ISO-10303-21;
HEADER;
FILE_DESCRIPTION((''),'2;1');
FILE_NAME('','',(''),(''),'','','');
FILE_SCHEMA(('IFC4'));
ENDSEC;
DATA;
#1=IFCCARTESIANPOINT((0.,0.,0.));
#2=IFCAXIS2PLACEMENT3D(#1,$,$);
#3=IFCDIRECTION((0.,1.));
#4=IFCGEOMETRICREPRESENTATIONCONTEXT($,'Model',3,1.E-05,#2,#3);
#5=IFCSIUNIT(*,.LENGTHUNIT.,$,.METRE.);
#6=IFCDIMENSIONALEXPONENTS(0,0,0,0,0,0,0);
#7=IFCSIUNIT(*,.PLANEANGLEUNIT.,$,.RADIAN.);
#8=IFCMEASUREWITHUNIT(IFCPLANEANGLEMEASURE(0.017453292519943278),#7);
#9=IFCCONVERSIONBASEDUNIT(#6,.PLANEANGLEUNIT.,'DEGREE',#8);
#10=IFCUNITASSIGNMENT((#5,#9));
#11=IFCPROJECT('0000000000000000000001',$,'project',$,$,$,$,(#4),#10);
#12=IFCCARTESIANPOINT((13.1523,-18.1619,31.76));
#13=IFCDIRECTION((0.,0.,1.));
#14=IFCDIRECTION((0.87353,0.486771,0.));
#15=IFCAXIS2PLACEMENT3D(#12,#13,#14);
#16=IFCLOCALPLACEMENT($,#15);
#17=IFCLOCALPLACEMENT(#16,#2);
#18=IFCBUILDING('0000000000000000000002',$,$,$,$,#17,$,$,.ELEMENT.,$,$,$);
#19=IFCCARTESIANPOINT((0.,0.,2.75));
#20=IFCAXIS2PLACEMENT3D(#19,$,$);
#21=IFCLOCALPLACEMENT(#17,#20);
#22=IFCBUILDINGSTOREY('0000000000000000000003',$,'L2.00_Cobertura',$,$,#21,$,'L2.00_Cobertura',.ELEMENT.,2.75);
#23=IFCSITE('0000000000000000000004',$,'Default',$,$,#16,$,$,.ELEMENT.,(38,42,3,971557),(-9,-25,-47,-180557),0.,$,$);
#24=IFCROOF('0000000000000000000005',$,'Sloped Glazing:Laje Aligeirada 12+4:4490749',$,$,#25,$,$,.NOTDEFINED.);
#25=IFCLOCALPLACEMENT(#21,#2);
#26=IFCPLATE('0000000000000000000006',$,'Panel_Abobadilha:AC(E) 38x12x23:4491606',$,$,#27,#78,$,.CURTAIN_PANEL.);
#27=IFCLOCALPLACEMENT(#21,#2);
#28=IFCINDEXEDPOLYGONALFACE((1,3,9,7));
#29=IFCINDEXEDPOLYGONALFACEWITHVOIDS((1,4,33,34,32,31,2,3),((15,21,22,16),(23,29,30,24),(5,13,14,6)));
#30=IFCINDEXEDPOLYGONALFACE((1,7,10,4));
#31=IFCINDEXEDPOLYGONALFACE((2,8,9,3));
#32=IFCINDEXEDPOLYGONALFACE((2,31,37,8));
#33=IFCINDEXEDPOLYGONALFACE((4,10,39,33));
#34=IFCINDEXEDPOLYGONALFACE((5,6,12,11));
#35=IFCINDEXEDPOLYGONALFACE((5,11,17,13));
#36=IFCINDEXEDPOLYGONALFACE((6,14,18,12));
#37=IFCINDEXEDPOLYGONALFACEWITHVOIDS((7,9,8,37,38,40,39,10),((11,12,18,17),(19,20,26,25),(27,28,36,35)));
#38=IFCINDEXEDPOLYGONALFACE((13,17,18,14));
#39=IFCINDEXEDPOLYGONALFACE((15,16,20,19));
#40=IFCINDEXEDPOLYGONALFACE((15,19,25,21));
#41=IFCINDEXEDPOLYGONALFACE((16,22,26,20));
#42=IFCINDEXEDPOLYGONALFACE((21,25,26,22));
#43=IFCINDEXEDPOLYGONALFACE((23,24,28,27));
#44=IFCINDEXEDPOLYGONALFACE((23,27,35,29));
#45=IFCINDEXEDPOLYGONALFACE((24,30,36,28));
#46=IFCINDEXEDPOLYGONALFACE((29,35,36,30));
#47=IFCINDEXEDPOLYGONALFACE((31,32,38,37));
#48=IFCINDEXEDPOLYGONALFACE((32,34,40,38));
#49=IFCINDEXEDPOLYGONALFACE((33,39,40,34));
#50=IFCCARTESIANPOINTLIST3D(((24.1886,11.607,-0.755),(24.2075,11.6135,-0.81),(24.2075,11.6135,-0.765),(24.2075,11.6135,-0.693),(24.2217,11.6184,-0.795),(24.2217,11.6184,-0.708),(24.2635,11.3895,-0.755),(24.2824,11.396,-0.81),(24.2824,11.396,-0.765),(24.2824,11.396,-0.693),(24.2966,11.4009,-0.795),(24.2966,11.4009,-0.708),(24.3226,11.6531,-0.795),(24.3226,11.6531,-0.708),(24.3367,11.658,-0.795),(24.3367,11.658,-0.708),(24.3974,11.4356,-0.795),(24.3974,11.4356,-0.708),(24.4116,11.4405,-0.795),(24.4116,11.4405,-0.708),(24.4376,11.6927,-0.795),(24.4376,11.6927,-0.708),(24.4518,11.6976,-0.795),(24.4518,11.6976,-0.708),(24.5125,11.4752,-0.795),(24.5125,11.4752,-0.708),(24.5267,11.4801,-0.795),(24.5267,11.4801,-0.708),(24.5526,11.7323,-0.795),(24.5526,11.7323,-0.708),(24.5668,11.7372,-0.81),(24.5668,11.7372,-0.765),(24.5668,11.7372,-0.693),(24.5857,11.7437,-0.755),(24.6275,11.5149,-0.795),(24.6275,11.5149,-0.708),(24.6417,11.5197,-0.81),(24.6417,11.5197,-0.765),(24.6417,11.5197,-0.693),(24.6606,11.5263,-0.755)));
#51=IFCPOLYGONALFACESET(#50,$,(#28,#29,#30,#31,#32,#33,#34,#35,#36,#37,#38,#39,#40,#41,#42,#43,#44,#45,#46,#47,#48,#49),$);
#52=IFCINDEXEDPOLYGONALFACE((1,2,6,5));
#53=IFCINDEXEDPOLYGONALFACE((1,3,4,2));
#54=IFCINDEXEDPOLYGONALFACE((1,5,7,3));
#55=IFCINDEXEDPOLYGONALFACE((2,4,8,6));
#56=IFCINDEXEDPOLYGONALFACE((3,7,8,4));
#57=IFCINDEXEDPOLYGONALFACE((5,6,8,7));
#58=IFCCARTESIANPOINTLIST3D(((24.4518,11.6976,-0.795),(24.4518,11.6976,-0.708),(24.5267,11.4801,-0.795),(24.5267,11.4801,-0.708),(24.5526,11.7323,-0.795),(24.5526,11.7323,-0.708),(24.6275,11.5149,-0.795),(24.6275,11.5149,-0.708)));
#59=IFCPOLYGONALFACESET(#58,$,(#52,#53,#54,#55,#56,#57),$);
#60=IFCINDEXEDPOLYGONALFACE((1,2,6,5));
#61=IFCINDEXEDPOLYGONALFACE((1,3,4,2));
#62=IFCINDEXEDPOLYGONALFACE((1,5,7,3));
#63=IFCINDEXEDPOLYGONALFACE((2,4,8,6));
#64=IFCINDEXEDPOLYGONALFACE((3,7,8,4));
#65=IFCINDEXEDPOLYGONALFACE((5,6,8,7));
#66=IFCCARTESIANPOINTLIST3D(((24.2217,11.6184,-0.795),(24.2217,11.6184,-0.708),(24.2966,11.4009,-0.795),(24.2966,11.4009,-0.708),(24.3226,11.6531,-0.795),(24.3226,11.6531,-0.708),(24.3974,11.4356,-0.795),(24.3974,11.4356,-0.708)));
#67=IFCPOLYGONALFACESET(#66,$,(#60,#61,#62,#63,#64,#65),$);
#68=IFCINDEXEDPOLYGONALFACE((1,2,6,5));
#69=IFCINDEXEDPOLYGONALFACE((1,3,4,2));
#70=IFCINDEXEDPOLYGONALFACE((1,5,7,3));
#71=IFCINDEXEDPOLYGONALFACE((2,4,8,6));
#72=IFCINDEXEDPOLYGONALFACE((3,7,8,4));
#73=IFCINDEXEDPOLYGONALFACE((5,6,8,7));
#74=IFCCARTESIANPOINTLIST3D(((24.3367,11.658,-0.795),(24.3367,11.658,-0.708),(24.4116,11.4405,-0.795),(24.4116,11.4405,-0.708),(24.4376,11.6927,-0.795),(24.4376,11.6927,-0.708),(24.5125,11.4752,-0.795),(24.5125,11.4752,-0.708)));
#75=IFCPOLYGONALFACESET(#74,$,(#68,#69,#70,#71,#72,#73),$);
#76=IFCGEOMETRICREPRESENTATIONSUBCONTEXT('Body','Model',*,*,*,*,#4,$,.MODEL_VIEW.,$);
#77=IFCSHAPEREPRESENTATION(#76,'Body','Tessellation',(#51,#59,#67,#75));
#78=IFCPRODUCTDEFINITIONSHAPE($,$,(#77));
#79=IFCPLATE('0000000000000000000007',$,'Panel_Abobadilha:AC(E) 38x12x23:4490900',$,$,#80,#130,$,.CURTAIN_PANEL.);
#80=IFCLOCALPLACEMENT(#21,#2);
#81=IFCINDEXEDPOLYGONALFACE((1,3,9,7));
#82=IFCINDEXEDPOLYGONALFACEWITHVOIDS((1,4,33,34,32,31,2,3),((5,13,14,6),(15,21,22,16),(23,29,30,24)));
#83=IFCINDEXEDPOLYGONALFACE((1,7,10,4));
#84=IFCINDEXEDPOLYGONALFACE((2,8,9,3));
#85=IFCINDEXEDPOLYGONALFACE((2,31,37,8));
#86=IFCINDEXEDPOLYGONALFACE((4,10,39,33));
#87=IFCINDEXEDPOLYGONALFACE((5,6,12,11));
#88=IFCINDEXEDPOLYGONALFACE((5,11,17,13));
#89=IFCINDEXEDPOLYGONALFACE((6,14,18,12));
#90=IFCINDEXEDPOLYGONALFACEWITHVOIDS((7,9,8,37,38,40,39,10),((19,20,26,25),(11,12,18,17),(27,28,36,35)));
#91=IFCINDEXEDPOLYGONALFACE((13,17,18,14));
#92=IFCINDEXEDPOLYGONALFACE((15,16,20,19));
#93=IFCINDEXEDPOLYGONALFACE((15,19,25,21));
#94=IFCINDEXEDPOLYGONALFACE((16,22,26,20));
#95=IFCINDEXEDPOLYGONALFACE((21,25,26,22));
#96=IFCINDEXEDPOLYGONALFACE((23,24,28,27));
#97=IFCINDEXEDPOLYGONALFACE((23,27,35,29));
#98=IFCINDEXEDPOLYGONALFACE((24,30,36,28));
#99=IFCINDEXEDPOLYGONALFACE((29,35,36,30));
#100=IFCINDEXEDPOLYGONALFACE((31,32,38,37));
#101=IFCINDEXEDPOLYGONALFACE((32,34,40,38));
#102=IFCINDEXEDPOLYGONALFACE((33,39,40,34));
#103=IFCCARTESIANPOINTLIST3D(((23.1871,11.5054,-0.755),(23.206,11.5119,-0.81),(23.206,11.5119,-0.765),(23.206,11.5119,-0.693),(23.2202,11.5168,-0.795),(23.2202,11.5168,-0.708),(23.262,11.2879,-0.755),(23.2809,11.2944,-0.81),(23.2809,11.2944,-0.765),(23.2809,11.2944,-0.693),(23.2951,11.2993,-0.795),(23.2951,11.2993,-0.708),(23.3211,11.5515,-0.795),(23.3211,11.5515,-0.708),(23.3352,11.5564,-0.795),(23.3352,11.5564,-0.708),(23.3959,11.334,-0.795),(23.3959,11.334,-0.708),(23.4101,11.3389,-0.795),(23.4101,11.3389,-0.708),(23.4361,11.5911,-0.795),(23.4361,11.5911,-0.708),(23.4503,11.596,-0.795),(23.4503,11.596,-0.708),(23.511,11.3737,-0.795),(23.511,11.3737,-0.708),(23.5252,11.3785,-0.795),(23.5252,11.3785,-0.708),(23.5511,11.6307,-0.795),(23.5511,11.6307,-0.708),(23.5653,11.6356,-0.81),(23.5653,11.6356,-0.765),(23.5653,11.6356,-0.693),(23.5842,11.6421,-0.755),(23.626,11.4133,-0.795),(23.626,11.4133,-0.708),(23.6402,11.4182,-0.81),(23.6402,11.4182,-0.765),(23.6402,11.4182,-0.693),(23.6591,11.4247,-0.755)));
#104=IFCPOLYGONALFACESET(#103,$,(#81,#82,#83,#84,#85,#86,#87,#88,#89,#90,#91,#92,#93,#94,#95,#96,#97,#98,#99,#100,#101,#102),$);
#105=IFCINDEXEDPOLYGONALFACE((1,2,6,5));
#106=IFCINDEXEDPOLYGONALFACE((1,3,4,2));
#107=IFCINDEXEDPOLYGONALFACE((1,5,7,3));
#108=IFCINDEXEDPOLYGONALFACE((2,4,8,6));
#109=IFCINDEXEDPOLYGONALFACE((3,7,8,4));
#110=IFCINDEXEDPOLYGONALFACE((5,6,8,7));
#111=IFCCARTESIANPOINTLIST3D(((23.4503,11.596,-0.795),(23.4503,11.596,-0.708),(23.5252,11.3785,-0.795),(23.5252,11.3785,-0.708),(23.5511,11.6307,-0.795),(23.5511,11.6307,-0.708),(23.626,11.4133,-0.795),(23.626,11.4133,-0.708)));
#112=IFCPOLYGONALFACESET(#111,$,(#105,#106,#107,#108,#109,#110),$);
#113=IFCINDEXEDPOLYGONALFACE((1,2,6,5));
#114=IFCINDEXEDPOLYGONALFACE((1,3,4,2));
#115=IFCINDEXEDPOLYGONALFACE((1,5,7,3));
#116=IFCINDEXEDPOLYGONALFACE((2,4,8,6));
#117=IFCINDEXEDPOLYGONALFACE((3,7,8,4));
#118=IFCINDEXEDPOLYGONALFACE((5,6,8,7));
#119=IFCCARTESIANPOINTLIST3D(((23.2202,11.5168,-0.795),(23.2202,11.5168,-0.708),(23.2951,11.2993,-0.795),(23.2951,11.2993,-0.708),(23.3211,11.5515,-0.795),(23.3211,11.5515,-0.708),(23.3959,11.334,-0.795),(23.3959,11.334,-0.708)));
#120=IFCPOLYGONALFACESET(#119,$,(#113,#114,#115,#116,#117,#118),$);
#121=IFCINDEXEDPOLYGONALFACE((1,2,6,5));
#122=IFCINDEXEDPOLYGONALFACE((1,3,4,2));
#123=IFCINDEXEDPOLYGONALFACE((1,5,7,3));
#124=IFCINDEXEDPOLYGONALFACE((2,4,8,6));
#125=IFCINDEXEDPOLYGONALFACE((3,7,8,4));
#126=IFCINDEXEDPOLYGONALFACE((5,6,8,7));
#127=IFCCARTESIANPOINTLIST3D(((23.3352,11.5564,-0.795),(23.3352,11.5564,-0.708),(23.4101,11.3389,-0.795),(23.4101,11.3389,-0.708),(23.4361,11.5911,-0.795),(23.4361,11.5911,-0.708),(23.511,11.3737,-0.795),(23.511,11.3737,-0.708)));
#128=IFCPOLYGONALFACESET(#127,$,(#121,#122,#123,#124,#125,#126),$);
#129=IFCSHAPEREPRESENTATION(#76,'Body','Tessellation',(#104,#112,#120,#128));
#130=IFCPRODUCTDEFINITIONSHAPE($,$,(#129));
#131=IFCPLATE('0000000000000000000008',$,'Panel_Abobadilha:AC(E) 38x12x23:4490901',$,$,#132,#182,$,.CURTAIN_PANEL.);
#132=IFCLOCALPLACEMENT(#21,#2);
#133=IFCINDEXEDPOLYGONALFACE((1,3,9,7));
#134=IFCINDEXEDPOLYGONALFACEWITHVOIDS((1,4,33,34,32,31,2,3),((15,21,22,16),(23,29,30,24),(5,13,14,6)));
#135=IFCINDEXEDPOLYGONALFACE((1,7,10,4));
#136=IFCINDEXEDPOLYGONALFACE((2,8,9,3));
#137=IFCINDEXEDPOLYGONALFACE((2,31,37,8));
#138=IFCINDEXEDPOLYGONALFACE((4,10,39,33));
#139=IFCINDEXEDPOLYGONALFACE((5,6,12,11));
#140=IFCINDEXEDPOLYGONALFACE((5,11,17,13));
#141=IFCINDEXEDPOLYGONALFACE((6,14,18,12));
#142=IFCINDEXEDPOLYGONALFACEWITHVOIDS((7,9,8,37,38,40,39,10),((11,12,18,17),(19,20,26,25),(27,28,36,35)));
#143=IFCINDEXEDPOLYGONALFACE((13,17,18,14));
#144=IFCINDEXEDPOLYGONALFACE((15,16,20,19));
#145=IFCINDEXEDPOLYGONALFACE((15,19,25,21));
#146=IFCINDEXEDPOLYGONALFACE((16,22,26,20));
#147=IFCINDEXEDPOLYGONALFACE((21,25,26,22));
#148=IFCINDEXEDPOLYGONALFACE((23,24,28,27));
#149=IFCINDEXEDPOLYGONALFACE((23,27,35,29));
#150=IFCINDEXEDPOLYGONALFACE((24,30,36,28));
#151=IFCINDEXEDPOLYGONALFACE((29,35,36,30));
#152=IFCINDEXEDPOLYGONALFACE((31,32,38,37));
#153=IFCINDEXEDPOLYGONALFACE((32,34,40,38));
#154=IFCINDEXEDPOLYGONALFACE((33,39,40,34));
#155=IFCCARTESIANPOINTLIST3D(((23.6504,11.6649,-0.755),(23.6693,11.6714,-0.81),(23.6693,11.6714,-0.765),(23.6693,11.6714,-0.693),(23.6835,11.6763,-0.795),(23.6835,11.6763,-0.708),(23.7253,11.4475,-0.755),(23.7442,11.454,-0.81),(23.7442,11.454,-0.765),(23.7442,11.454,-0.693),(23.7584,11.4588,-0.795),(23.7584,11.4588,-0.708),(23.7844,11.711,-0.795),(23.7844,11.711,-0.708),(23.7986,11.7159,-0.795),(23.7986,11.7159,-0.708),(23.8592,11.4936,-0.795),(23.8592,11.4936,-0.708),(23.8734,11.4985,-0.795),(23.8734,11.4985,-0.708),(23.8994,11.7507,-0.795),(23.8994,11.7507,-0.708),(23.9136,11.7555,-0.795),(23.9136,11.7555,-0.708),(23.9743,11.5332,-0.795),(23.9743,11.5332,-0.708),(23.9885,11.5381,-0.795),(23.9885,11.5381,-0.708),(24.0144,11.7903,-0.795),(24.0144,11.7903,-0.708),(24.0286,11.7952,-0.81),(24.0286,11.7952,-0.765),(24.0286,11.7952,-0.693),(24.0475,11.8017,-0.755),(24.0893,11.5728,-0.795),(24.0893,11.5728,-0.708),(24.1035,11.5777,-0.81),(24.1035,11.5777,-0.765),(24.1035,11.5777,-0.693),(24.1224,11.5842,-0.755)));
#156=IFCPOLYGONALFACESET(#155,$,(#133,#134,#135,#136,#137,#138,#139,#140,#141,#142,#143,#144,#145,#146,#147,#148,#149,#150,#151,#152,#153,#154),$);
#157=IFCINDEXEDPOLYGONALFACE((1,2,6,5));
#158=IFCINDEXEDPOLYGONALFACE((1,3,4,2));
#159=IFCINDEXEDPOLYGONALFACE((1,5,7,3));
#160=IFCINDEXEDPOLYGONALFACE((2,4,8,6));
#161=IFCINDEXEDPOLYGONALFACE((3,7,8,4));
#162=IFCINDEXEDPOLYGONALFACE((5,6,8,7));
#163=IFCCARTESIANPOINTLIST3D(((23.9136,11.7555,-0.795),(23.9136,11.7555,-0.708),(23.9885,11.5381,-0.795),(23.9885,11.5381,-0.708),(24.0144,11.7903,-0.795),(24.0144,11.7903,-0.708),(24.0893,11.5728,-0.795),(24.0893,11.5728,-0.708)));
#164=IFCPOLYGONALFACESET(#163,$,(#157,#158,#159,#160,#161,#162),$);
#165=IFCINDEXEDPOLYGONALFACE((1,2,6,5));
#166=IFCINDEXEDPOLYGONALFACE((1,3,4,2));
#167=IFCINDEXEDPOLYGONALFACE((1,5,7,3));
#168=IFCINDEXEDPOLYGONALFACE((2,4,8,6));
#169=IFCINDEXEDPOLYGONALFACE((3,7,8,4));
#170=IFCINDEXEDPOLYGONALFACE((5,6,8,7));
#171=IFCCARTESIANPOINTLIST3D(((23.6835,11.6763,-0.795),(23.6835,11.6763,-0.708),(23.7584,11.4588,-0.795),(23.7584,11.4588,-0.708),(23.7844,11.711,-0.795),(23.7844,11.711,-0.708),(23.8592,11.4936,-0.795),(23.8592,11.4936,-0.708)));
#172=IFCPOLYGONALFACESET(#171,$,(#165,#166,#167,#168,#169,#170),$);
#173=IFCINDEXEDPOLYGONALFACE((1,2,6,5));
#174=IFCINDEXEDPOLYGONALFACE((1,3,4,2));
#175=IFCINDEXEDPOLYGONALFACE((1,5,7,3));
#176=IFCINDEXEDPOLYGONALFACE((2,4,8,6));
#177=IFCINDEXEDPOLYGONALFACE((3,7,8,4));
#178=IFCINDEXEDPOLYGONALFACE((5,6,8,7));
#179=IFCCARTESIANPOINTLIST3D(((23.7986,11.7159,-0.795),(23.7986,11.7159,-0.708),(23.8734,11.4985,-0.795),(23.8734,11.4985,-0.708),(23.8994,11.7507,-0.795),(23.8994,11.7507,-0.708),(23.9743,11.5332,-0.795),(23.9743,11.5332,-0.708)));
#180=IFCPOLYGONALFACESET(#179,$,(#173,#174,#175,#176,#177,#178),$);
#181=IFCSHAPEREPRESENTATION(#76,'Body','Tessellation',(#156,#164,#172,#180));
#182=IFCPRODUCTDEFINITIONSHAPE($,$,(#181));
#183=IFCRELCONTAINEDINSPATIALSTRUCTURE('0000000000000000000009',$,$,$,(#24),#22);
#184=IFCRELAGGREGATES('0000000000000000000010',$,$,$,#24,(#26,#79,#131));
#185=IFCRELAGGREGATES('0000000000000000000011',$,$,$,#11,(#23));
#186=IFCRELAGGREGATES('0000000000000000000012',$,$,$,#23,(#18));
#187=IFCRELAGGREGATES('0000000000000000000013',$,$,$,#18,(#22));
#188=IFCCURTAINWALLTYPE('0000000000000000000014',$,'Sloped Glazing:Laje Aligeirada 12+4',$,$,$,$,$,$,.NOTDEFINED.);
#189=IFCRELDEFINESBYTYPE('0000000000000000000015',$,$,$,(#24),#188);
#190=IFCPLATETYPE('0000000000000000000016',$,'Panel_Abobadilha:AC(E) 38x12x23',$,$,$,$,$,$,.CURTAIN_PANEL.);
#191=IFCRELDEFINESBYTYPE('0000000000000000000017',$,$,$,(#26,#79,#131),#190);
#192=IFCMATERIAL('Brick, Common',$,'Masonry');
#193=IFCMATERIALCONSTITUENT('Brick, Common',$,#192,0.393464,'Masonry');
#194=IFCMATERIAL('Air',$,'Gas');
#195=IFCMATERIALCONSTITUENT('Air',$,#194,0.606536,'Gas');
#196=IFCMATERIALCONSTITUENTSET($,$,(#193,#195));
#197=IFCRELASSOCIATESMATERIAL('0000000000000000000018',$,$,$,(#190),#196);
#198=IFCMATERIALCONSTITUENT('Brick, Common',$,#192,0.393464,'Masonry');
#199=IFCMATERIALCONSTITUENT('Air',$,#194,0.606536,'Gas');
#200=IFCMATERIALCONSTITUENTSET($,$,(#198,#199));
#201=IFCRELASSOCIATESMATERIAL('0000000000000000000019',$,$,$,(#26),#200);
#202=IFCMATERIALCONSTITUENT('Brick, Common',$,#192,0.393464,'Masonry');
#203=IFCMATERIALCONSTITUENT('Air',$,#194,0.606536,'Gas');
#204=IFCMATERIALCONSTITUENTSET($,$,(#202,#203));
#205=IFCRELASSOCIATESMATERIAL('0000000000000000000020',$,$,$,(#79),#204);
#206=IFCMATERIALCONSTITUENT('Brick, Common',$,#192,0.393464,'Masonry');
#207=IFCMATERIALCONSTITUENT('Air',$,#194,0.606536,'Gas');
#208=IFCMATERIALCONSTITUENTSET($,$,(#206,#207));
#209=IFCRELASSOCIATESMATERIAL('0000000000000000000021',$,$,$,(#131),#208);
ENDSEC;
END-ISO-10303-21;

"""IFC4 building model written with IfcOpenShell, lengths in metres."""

from ifc_helpers import new_model, entity, si_unit, converted_unit, direction, frame, origin, place, context, subcontext, project, spatial, indexed_curve, outline, extrude, source, transform, mapped, material, constituent, constituent_set, type_object, type_shapes, element, aggregate, save


model = new_model("IFC4")

# Units and contexts
model_context = context("Model", 3, precision=1e-05, world=origin(), true_north=direction((0.0, 1.0)))
body_context = subcontext(model_context, "Body", "Model", "MODEL_VIEW")
ifc_project = project(units=[si_unit("LENGTHUNIT", "METRE"), converted_unit("PLANEANGLEUNIT", "DEGREE", entity("IfcPlaneAngleMeasure", 0.017453292519943278), si_unit("PLANEANGLEUNIT", "RADIAN"), dimensions=[0, 0, 0, 0, 0, 0, 0])], contexts=[model_context])

# Site, building, storey
site_placement = place(None, frame((13.1523, -18.1619, 31.76), z_axis=(0.0, 0.0, 1.0), x_axis=(0.87353, 0.486771, 0.0)))
site = spatial("IfcSite", under=ifc_project, at=site_placement, Name="Default", CompositionType="ELEMENT", RefLatitude=(38, 42, 3, 971557), RefLongitude=(-9, -25, -47, -180557), RefElevation=0.0)
building_placement = place(site_placement, origin())
building = spatial("IfcBuilding", under=site, at=building_placement, CompositionType="ELEMENT")
storey_placement = place(building_placement, frame((0.0, 0.0, 2.75)))
storey = spatial("IfcBuildingStorey", under=building, at=storey_placement, Name="L2.00_Cobertura", LongName="L2.00_Cobertura", CompositionType="ELEMENT", Elevation=2.75)

# Roof, plates
curtain_wall_type = type_object("IfcCurtainWallType", Name="Sloped Glazing:Laje Aligeirada 12+4", PredefinedType="NOTDEFINED")
roof_placement = place(storey_placement, frame((0.0, 0.0, -2.75)))
roof = element("IfcRoof", 1, at=roof_placement, inside=storey, type_object=curtain_wall_type, Name="Sloped Glazing:Laje Aligeirada 12+4:4490749", PredefinedType="NOTDEFINED")
ifc_material_1 = material(Name="Brick, Common", Category="Masonry")
ifc_material_2 = material(Name="Air", Category="Gas")
ifc_constituent_1 = constituent(ifc_material_1, Name="Brick, Common", Category="Masonry", fraction=0.393464)
ifc_constituent_2 = constituent(ifc_material_2, Name="Air", Category="Gas", fraction=0.606536)
ifc_constituent_set_1 = constituent_set(constituents=[ifc_constituent_1, ifc_constituent_2])
plate_type_1 = type_object("IfcPlateType", Name="Panel_Abobadilha:AC(E) 38x12x23", PredefinedType="CURTAIN_PANEL", material=ifc_constituent_set_1)
shared_shape_1 = source(origin(), body_context, "Body", "SweptSolid", [
    extrude(outline(indexed_curve([(-0.19, -0.0543), (0.19, -0.0543), (0.19, -0.0093), (0.21, 0.0007), (0.19, 0.0628), (-0.19, 0.0628), (-0.21, 0.0007), (-0.19, -0.0093), (-0.19, -0.0543)], self_intersect=False), holes=[indexed_curve([(-0.0683, 0.0477), (-0.0683, -0.0393), (-0.175, -0.0393), (-0.175, 0.0477), (-0.0683, 0.0477)], self_intersect=False), indexed_curve([(0.0533, 0.0477), (0.0533, -0.0393), (-0.0533, -0.0393), (-0.0533, 0.0477), (0.0533, 0.0477)], self_intersect=False), indexed_curve([(0.175, 0.0477), (0.175, -0.0393), (0.0683, -0.0393), (0.0683, 0.0477), (0.175, 0.0477)], self_intersect=False)]), frame((0.0, 0.0543, 0.0)), (0.0, 0.0, 1.0), 0.23),
    extrude(outline(indexed_curve([(-0.0533, -0.0435), (0.0533, -0.0435), (0.0533, 0.0435), (-0.0533, 0.0435), (-0.0533, -0.0435)], self_intersect=False)), frame((0.1217, 0.0585, 0.0), z_axis=(0.0, 0.0, 1.0), x_axis=(-1.0, 0.0, 0.0)), (0.0, 0.0, 1.0), 0.23),
    extrude(outline(indexed_curve([(-0.0533, -0.0435), (0.0533, -0.0435), (0.0533, 0.0435), (-0.0533, 0.0435), (-0.0533, -0.0435)], self_intersect=False)), frame((-0.1217, 0.0585, 0.0), z_axis=(0.0, 0.0, 1.0), x_axis=(-1.0, 0.0, 0.0)), (0.0, 0.0, 1.0), 0.23),
    extrude(outline(indexed_curve([(-0.0533, -0.0435), (0.0533, -0.0435), (0.0533, 0.0435), (-0.0533, 0.0435), (-0.0533, -0.0435)], self_intersect=False)), frame((0.0, 0.0585, 0.0), z_axis=(0.0, 0.0, 1.0), x_axis=(-1.0, 0.0, 0.0)), (0.0, 0.0, 1.0), 0.23),
])
type_shapes(plate_type_1, [shared_shape_1])
ifc_constituent_3 = constituent(ifc_material_1, Name="Brick, Common", Category="Masonry", fraction=0.393464)
ifc_constituent_4 = constituent(ifc_material_2, Name="Air", Category="Gas", fraction=0.606536)
ifc_constituent_set_2 = constituent_set(constituents=[ifc_constituent_3, ifc_constituent_4])
plate_1_placement = place(roof_placement, frame((24.3872, 11.6754, 1.94), z_axis=(0.325568, -0.945519, 0.0), x_axis=(0.945519, 0.325568, 0.0)))
plate_1 = element("IfcPlate", 2, at=plate_1_placement, type_object=plate_type_1, material=ifc_constituent_set_2, Name="Panel_Abobadilha:AC(E) 38x12x23:4491606", PredefinedType="CURTAIN_PANEL", context=body_context, shape_type="MappedRepresentation", body=[
    mapped(shared_shape_1, transform((0.0, 0.0, 0.0), scale=1.0)),
])
ifc_constituent_5 = constituent(ifc_material_1, Name="Brick, Common", Category="Masonry", fraction=0.393464)
ifc_constituent_6 = constituent(ifc_material_2, Name="Air", Category="Gas", fraction=0.606536)
ifc_constituent_set_3 = constituent_set(constituents=[ifc_constituent_5, ifc_constituent_6])
plate_2_placement = place(roof_placement, frame((23.3857, 11.5738, 1.94), z_axis=(0.325568, -0.945519, 0.0), x_axis=(0.945519, 0.325568, 0.0)))
plate_2 = element("IfcPlate", 3, at=plate_2_placement, type_object=plate_type_1, material=ifc_constituent_set_3, Name="Panel_Abobadilha:AC(E) 38x12x23:4490900", PredefinedType="CURTAIN_PANEL", context=body_context, shape_type="MappedRepresentation", body=[
    mapped(shared_shape_1, transform((0.0, 0.0, 0.0), scale=1.0)),
])
ifc_constituent_7 = constituent(ifc_material_1, Name="Brick, Common", Category="Masonry", fraction=0.393464)
ifc_constituent_8 = constituent(ifc_material_2, Name="Air", Category="Gas", fraction=0.606536)
ifc_constituent_set_4 = constituent_set(constituents=[ifc_constituent_7, ifc_constituent_8])
plate_3_placement = place(roof_placement, frame((23.849, 11.7333, 1.94), z_axis=(0.325568, -0.945519, 0.0), x_axis=(0.945519, 0.325568, 0.0)))
plate_3 = element("IfcPlate", 4, at=plate_3_placement, type_object=plate_type_1, material=ifc_constituent_set_4, Name="Panel_Abobadilha:AC(E) 38x12x23:4490901", PredefinedType="CURTAIN_PANEL", context=body_context, shape_type="MappedRepresentation", body=[
    mapped(shared_shape_1, transform((0.0, 0.0, 0.0), scale=1.0)),
])
aggregate(roof, [plate_1, plate_2, plate_3])

save(model, "model.ifc")
